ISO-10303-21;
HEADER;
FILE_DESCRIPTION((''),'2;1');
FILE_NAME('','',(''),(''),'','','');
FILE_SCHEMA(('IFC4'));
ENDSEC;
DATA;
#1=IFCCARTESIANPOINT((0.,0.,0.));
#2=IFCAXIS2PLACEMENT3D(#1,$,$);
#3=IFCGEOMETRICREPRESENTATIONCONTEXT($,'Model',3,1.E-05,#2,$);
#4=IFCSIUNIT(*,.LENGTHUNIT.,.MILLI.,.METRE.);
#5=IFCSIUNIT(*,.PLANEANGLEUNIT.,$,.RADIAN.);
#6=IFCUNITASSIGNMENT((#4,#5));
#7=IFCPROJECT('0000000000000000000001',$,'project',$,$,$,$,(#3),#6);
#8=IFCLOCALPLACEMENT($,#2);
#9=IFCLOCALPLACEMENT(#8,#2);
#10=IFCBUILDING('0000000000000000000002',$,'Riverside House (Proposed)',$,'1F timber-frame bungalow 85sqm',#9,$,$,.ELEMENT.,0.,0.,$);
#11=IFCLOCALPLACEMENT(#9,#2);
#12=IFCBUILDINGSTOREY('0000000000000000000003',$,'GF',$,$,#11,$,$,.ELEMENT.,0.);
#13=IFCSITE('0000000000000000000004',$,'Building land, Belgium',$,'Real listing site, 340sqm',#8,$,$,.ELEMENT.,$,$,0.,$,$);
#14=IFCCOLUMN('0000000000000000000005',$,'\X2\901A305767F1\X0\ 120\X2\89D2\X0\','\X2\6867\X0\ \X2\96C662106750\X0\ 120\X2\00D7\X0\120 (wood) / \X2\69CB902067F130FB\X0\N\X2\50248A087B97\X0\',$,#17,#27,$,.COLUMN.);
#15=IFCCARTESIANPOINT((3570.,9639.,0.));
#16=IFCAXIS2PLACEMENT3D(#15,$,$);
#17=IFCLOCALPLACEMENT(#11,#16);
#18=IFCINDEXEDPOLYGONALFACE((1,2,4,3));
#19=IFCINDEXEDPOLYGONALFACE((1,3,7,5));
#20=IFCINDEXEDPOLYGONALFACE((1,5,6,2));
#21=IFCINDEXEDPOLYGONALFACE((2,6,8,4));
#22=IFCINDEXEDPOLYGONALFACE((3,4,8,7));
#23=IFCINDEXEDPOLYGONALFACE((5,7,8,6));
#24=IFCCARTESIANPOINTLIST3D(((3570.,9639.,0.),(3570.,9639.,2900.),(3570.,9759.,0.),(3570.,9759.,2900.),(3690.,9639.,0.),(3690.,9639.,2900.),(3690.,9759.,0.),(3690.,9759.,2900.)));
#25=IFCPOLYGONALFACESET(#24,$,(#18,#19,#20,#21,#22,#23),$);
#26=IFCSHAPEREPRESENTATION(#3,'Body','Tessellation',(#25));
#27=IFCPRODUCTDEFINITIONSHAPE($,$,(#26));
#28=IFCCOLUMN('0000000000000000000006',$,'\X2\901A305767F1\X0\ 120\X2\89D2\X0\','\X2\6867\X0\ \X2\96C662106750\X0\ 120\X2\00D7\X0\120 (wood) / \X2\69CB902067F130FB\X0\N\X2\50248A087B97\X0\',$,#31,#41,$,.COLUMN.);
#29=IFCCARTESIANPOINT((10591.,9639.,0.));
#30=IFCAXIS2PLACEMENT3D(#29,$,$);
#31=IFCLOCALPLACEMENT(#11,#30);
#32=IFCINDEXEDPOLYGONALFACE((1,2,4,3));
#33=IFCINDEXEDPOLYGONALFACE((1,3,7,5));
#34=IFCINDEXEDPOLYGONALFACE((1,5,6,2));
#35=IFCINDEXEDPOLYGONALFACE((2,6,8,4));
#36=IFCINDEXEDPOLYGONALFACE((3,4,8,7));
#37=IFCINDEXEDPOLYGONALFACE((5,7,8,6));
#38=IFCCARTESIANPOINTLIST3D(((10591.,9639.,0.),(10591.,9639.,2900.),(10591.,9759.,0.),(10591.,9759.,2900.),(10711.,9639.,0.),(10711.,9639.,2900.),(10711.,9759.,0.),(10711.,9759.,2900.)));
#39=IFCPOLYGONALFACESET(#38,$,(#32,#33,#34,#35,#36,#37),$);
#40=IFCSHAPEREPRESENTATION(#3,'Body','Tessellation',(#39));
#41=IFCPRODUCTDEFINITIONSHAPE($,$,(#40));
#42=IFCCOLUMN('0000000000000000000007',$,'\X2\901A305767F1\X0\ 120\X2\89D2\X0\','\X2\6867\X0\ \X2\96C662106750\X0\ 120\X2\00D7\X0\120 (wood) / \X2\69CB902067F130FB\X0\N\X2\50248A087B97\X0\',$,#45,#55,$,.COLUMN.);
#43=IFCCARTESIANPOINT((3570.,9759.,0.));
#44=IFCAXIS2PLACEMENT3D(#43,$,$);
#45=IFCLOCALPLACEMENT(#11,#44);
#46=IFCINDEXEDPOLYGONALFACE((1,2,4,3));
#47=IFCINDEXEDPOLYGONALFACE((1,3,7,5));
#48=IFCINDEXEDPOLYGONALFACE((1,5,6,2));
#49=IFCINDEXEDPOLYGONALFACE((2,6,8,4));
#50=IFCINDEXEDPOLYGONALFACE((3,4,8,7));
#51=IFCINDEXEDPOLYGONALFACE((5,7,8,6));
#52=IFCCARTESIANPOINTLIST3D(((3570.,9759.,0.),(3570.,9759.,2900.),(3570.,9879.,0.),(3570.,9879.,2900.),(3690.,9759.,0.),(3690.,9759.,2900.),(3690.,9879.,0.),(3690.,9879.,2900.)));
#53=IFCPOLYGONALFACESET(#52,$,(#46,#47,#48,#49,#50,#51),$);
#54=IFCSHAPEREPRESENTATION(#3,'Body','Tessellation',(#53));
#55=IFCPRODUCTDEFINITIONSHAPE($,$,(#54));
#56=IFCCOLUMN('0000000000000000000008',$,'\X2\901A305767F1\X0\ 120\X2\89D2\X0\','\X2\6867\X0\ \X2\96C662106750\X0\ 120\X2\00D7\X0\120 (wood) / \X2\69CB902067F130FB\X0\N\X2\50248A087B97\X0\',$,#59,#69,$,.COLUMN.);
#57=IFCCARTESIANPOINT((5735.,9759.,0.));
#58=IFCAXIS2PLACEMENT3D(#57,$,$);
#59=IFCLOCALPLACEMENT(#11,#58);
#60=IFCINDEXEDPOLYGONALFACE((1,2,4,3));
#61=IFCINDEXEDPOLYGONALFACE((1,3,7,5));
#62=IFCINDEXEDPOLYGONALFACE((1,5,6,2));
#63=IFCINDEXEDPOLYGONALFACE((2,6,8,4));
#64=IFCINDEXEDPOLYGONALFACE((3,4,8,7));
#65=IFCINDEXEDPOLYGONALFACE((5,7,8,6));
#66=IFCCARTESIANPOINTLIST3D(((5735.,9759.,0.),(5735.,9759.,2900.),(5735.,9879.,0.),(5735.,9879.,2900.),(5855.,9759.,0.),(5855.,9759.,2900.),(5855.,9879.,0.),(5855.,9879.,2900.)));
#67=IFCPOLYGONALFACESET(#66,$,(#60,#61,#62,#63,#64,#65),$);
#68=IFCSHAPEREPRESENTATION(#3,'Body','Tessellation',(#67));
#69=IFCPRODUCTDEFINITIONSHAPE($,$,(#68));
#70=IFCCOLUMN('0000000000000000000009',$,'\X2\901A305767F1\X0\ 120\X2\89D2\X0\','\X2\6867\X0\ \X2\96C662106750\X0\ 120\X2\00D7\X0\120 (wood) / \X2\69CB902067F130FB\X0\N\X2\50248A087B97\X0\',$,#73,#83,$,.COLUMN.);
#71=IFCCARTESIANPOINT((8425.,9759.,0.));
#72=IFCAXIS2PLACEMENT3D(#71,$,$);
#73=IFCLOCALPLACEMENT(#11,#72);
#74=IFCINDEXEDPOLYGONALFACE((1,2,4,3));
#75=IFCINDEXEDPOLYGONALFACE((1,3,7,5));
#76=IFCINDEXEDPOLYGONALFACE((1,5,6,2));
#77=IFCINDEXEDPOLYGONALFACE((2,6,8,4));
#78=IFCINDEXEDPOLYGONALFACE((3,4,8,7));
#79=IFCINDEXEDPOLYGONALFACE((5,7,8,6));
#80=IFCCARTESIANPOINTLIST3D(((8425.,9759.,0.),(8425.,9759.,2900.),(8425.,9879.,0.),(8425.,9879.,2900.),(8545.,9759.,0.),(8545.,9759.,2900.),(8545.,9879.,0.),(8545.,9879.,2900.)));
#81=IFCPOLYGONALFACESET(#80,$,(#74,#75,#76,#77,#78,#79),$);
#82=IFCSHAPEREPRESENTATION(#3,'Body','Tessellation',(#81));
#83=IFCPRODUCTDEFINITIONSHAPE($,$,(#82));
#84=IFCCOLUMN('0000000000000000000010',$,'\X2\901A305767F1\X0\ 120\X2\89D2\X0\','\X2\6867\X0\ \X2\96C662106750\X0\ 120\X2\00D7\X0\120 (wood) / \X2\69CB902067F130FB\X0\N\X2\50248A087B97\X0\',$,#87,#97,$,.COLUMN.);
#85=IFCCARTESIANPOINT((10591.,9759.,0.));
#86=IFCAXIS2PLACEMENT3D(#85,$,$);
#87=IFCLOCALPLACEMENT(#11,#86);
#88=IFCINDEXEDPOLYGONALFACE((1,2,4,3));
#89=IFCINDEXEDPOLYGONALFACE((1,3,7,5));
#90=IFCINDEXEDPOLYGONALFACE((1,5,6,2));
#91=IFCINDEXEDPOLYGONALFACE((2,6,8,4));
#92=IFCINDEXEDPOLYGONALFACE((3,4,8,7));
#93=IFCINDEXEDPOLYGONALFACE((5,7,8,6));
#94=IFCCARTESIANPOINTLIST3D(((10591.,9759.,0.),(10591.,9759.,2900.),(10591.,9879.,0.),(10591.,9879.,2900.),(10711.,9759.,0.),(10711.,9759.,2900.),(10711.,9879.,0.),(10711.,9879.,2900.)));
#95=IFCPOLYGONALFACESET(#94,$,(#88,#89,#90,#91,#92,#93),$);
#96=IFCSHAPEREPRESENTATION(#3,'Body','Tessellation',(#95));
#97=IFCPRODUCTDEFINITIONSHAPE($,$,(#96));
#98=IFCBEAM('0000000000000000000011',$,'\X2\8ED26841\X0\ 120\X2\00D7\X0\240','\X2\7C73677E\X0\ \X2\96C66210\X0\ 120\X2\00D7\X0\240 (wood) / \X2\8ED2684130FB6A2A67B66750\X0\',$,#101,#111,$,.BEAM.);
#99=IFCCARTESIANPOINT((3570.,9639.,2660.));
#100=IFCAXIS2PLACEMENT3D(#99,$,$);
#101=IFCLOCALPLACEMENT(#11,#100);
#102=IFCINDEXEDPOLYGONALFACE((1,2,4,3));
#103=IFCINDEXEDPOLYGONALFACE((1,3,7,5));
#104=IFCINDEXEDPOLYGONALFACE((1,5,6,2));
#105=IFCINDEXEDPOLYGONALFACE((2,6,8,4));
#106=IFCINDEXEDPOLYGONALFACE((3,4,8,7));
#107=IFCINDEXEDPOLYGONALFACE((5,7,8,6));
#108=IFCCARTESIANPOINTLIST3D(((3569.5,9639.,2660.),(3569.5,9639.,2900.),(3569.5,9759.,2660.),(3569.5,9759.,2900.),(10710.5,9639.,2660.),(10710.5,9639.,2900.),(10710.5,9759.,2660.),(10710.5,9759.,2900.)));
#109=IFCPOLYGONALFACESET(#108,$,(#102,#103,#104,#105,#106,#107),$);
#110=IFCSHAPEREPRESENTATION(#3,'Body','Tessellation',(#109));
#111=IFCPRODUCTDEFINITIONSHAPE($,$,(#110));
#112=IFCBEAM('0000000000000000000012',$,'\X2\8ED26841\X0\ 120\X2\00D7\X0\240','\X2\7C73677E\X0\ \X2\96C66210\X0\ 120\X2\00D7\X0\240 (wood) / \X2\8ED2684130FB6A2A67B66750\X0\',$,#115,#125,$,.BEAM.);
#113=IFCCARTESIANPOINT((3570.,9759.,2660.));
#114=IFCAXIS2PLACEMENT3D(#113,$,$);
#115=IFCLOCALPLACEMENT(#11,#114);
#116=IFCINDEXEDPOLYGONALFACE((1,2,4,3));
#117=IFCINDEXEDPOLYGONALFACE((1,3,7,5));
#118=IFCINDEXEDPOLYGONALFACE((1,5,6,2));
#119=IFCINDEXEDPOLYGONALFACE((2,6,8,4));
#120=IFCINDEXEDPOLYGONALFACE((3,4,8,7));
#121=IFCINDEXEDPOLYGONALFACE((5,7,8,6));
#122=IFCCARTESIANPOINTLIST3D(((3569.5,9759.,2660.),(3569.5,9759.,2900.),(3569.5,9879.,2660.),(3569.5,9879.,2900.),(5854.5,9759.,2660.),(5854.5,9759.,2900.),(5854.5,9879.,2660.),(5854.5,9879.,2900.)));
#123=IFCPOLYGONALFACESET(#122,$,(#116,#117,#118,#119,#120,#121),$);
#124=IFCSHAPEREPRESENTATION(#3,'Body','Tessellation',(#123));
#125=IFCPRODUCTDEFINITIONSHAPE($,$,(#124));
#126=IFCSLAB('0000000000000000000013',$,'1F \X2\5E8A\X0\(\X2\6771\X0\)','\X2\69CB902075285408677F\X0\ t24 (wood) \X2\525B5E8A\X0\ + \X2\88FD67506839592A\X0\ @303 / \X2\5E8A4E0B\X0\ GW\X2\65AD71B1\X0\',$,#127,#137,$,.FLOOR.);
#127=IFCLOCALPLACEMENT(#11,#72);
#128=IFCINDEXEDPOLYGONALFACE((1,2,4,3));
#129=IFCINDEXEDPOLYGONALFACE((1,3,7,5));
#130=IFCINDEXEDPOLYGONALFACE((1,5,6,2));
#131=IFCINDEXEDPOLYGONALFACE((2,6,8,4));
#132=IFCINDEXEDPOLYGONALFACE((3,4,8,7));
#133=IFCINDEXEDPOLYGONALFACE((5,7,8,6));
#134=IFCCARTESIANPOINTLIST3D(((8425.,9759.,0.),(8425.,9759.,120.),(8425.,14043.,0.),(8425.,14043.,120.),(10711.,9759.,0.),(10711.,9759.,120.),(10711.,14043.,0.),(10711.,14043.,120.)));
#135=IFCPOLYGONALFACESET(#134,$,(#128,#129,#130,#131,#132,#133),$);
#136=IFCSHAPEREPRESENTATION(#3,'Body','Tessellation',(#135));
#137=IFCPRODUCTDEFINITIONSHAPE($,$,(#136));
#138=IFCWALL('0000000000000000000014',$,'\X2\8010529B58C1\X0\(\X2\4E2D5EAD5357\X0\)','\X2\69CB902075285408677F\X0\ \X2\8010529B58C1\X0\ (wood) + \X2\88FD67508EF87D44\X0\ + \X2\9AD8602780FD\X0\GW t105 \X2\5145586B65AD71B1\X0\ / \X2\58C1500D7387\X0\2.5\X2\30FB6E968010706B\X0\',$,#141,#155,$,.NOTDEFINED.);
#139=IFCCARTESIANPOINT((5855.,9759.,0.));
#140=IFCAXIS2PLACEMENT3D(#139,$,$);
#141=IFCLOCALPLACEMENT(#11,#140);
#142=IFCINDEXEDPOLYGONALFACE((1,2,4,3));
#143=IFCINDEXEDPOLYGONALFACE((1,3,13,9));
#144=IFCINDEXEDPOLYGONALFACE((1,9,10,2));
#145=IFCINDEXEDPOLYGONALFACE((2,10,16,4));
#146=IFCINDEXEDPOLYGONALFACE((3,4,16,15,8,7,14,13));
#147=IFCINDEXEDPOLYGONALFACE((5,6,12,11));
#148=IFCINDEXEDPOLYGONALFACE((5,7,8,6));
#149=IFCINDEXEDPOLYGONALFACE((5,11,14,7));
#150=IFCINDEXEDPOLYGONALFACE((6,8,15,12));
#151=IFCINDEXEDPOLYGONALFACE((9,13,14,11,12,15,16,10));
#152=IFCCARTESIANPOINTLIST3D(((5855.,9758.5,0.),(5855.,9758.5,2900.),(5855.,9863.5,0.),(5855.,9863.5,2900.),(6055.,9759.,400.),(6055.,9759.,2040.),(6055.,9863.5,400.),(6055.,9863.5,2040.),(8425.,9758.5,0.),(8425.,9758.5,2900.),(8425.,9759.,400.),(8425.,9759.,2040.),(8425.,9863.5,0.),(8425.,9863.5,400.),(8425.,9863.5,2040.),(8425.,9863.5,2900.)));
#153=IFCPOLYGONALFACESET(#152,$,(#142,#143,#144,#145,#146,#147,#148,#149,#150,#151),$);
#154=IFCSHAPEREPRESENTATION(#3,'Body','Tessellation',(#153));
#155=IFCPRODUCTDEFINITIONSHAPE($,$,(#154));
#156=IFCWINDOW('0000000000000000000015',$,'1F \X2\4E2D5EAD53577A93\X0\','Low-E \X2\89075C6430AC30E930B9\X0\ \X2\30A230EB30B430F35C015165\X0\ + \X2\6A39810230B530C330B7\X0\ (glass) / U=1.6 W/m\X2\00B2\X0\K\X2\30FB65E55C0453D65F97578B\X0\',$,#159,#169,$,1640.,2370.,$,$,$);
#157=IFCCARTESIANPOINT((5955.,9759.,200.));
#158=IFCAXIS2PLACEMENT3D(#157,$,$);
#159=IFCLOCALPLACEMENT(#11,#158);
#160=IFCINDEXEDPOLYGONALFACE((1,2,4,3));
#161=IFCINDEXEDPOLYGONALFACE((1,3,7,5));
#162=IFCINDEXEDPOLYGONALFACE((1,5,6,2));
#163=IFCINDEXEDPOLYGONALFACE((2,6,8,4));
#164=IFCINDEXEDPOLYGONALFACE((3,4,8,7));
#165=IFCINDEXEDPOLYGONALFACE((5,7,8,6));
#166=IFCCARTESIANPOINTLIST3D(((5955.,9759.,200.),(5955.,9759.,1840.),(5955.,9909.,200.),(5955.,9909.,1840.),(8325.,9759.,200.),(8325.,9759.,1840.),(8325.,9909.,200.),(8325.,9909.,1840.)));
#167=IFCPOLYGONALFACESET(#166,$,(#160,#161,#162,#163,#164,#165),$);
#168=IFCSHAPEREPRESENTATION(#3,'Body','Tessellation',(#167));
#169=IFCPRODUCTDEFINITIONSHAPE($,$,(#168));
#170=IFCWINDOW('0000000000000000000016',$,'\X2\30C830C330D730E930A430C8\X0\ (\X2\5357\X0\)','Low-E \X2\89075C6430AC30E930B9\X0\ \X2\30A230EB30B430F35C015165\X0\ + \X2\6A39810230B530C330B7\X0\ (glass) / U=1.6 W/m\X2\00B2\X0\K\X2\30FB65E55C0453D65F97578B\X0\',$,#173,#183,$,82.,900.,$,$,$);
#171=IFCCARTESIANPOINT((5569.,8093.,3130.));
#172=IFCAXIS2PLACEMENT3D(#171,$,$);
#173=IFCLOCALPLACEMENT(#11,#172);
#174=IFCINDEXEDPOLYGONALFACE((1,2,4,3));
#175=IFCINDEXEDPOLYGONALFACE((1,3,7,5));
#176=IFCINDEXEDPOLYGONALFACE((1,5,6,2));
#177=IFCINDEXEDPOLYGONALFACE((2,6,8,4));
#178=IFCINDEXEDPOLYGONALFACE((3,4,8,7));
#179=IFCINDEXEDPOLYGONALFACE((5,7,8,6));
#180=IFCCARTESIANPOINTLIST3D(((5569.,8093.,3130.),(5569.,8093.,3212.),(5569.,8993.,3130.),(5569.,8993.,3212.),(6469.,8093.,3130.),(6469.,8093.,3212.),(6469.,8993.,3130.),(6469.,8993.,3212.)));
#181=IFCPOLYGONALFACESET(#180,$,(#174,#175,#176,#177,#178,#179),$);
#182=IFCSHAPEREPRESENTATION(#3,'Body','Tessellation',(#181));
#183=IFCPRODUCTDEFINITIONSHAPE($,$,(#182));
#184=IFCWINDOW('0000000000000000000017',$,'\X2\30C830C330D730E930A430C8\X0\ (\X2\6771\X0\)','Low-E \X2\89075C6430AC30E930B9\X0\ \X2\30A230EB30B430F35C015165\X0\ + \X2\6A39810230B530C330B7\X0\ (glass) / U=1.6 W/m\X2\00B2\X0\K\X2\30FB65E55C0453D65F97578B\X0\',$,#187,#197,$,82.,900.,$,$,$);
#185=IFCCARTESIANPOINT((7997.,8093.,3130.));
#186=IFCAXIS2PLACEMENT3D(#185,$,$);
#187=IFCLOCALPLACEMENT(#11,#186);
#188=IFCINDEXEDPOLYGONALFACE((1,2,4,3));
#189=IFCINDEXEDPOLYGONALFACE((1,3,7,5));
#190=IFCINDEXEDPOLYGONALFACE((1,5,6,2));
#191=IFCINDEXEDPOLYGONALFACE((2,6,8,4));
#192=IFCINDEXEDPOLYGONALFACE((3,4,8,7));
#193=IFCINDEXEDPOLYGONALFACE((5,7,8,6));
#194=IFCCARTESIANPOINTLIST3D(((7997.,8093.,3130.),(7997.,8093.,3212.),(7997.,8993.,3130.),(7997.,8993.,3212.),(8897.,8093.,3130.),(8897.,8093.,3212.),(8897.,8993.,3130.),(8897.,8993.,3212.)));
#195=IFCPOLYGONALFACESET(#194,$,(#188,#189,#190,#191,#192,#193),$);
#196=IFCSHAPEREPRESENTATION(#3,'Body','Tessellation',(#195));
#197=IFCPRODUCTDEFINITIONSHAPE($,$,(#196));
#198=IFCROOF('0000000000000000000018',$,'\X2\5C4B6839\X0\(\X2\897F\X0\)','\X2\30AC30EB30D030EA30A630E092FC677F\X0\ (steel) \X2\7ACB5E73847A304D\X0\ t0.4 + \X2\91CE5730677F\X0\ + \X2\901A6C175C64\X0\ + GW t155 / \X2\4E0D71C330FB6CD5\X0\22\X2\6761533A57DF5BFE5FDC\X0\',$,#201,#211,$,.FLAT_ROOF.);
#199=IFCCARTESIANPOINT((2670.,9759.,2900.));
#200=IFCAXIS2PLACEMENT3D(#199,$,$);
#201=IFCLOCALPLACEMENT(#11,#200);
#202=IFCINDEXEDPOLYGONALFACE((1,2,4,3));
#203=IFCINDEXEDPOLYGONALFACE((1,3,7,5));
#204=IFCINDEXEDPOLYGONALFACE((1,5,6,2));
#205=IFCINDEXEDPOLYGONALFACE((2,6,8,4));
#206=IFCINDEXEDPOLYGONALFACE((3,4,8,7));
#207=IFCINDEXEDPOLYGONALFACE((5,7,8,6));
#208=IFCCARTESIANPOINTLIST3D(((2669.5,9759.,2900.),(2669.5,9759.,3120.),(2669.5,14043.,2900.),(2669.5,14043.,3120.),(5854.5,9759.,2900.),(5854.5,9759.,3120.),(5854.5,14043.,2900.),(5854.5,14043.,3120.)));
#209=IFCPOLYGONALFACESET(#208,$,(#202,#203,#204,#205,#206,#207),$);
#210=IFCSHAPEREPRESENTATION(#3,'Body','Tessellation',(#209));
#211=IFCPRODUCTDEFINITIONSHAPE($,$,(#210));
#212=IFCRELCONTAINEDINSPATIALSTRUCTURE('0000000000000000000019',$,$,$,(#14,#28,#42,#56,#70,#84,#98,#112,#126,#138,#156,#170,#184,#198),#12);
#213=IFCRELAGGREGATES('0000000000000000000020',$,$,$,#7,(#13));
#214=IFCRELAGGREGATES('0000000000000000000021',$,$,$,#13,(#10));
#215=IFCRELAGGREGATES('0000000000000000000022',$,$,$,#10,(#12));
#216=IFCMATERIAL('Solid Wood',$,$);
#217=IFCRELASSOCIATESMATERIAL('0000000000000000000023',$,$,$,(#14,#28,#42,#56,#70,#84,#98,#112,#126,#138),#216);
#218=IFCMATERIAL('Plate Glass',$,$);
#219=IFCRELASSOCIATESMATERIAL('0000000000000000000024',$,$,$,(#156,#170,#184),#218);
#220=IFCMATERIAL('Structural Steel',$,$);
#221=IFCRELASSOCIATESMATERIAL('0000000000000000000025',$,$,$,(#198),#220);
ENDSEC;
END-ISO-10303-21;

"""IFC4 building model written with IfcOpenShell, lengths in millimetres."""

from ifc_helpers import new_model, si_unit, frame, frame_2d, origin, place, context, project, spatial, rectangle, extrude, material, element, fill, save


model = new_model("IFC4")

# Units and contexts
model_context = context("Model", 3, precision=1e-05, world=origin())
ifc_project = project(units=[si_unit("LENGTHUNIT", "METRE", prefix="MILLI"), si_unit("PLANEANGLEUNIT", "RADIAN")], contexts=[model_context])

# Site, building, storey
site_placement = place(None, origin())
site = spatial("IfcSite", under=ifc_project, at=site_placement, Name="Building land, Belgium", ObjectType="Real listing site, 340sqm", CompositionType="ELEMENT", RefElevation=0.0)
building_placement = place(site_placement, origin())
building = spatial("IfcBuilding", under=site, at=building_placement, Name="Riverside House (Proposed)", ObjectType="1F timber-frame bungalow 85sqm", CompositionType="ELEMENT", ElevationOfRefHeight=0.0, ElevationOfTerrain=0.0)
storey_placement = place(building_placement, origin())
storey = spatial("IfcBuildingStorey", under=building, at=storey_placement, Name="GF", CompositionType="ELEMENT", Elevation=0.0)

# Columns
ifc_material_1 = material(Name="Solid Wood")
column_1_placement = place(storey_placement, frame((3570.0, 9639.0, 0.0)))
element("IfcColumn", 1, at=column_1_placement, inside=storey, material=ifc_material_1, Name="通し柱 120角", Description="桧 集成材 120×120 (wood) / 構造柱・N値計算", PredefinedType="COLUMN", context=model_context, shape_type="SweptSolid", body=[
    extrude(rectangle(XDim=120.0, YDim=120.0, at=frame_2d((60.0, 60.0))), frame((3570.0, 9639.0, 0.0)), (0.0, 0.0, 1.0), 2900.0),
])
column_2_placement = place(storey_placement, frame((10591.0, 9639.0, 0.0)))
element("IfcColumn", 2, at=column_2_placement, inside=storey, material=ifc_material_1, Name="通し柱 120角", Description="桧 集成材 120×120 (wood) / 構造柱・N値計算", PredefinedType="COLUMN", context=model_context, shape_type="SweptSolid", body=[
    extrude(rectangle(XDim=120.0, YDim=120.0, at=frame_2d((60.0, 60.0))), frame((10591.0, 9639.0, 0.0)), (0.0, 0.0, 1.0), 2900.0),
])
column_3_placement = place(storey_placement, frame((3570.0, 9759.0, 0.0)))
element("IfcColumn", 3, at=column_3_placement, inside=storey, material=ifc_material_1, Name="通し柱 120角", Description="桧 集成材 120×120 (wood) / 構造柱・N値計算", PredefinedType="COLUMN", context=model_context, shape_type="SweptSolid", body=[
    extrude(rectangle(XDim=120.0, YDim=120.0, at=frame_2d((60.0, 60.0))), frame((3570.0, 9759.0, 0.0)), (0.0, 0.0, 1.0), 2900.0),
])
column_4_placement = place(storey_placement, frame((5735.0, 9759.0, 0.0)))
element("IfcColumn", 4, at=column_4_placement, inside=storey, material=ifc_material_1, Name="通し柱 120角", Description="桧 集成材 120×120 (wood) / 構造柱・N値計算", PredefinedType="COLUMN", context=model_context, shape_type="SweptSolid", body=[
    extrude(rectangle(XDim=120.0, YDim=120.0, at=frame_2d((60.0, 60.0))), frame((5735.0, 9759.0, 0.0)), (0.0, 0.0, 1.0), 2900.0),
])
column_5_placement = place(storey_placement, frame((8425.0, 9759.0, 0.0)))
element("IfcColumn", 5, at=column_5_placement, inside=storey, material=ifc_material_1, Name="通し柱 120角", Description="桧 集成材 120×120 (wood) / 構造柱・N値計算", PredefinedType="COLUMN", context=model_context, shape_type="SweptSolid", body=[
    extrude(rectangle(XDim=120.0, YDim=120.0, at=frame_2d((60.0, 60.0))), frame((8425.0, 9759.0, 0.0)), (0.0, 0.0, 1.0), 2900.0),
])
column_6_placement = place(storey_placement, frame((10591.0, 9759.0, 0.0)))
element("IfcColumn", 6, at=column_6_placement, inside=storey, material=ifc_material_1, Name="通し柱 120角", Description="桧 集成材 120×120 (wood) / 構造柱・N値計算", PredefinedType="COLUMN", context=model_context, shape_type="SweptSolid", body=[
    extrude(rectangle(XDim=120.0, YDim=120.0, at=frame_2d((60.0, 60.0))), frame((10591.0, 9759.0, 0.0)), (0.0, 0.0, 1.0), 2900.0),
])

# Beams
beam_1_placement = place(storey_placement, frame((3570.0, 9639.0, 2660.0)))
element("IfcBeam", 7, at=beam_1_placement, inside=storey, material=ifc_material_1, Name="軒桁 120×240", Description="米松 集成 120×240 (wood) / 軒桁・横架材", PredefinedType="BEAM", context=model_context, shape_type="SweptSolid", body=[
    extrude(rectangle(XDim=7141.0, YDim=120.0, at=frame_2d((3570.0, 60.0))), frame((3570.0, 9639.0, 2660.0)), (0.0, 0.0, 1.0), 240.0),
])
beam_2_placement = place(storey_placement, frame((3570.0, 9759.0, 2660.0)))
element("IfcBeam", 8, at=beam_2_placement, inside=storey, material=ifc_material_1, Name="軒桁 120×240", Description="米松 集成 120×240 (wood) / 軒桁・横架材", PredefinedType="BEAM", context=model_context, shape_type="SweptSolid", body=[
    extrude(rectangle(XDim=2285.0, YDim=120.0, at=frame_2d((1142.0, 60.0))), frame((3570.0, 9759.0, 2660.0)), (0.0, 0.0, 1.0), 240.0),
])

# Slab
slab_1_placement = place(storey_placement, frame((8425.0, 9759.0, 0.0)))
element("IfcSlab", 9, at=slab_1_placement, inside=storey, material=ifc_material_1, Name="1F 床(東)", Description="構造用合板 t24 (wood) 剛床 + 製材根太 @303 / 床下 GW断熱", PredefinedType="FLOOR", context=model_context, shape_type="SweptSolid", body=[
    extrude(rectangle(XDim=2286.0, YDim=4284.0, at=frame_2d((1143.0, 2142.0))), frame((8425.0, 9759.0, 0.0)), (0.0, 0.0, 1.0), 120.0),
])

# Wall, opening, window
wall_1_placement = place(storey_placement, frame((5855.0, 9759.0, 0.0)))
wall_1 = element("IfcWall", 10, at=wall_1_placement, inside=storey, material=ifc_material_1, Name="耐力壁(中庭南)", Description="構造用合板 耐力壁 (wood) + 製材軸組 + 高性能GW t105 充填断熱 / 壁倍率2.5・準耐火", PredefinedType="NOTDEFINED", context=model_context, shape_type="SweptSolid", body=[
    extrude(rectangle(XDim=2570.0, YDim=105.0, at=frame_2d((1285.0, 52.0))), frame((5855.0, 9759.0, 0.0)), (0.0, 0.0, 1.0), 2900.0),
])
opening_placement = place(storey_placement, frame((5955.0, 9759.0, 200.0)))
opening = element("IfcOpeningElement", 11, at=opening_placement, cuts=wall_1, PredefinedType="NOTDEFINED", context=model_context, shape_type="SweptSolid", body=[
    extrude(rectangle(XDim=2370.0, YDim=150.0, at=frame_2d((1185.0, 75.0))), frame((5955.0, 9759.0, 200.0)), (0.0, 0.0, 1.0), 1640.0),
])
ifc_material_2 = material(Name="Plate Glass")
window_1_placement = place(storey_placement, frame((5955.0, 9759.0, 200.0)))
window_1 = element("IfcWindow", 12, at=window_1_placement, inside=storey, material=ifc_material_2, Name="1F 中庭南窓", Description="Low-E 複層ガラス アルゴン封入 + 樹脂サッシ (glass) / U=1.6 W/m²K・日射取得型", OverallHeight=1640.0, OverallWidth=2370.0, context=model_context, shape_type="SweptSolid", body=[
    extrude(rectangle(XDim=2370.0, YDim=150.0, at=frame_2d((1185.0, 75.0))), frame((5955.0, 9759.0, 200.0)), (0.0, 0.0, 1.0), 1640.0),
])
fill(opening, window_1)

# Windows
window_2_placement = place(storey_placement, frame((5569.0, 8093.0, 3130.0)))
element("IfcWindow", 13, at=window_2_placement, inside=storey, material=ifc_material_2, Name="トップライト (南)", Description="Low-E 複層ガラス アルゴン封入 + 樹脂サッシ (glass) / U=1.6 W/m²K・日射取得型", OverallHeight=82.0, OverallWidth=900.0, context=model_context, shape_type="SweptSolid", body=[
    extrude(rectangle(XDim=900.0, YDim=900.0, at=frame_2d((450.0, 450.0))), frame((5569.0, 8093.0, 3130.0)), (0.0, 0.0, 1.0), 82.0),
])
window_3_placement = place(storey_placement, frame((7997.0, 8093.0, 3130.0)))
element("IfcWindow", 14, at=window_3_placement, inside=storey, material=ifc_material_2, Name="トップライト (東)", Description="Low-E 複層ガラス アルゴン封入 + 樹脂サッシ (glass) / U=1.6 W/m²K・日射取得型", OverallHeight=82.0, OverallWidth=900.0, context=model_context, shape_type="SweptSolid", body=[
    extrude(rectangle(XDim=900.0, YDim=900.0, at=frame_2d((450.0, 450.0))), frame((7997.0, 8093.0, 3130.0)), (0.0, 0.0, 1.0), 82.0),
])

# Roof
ifc_material_3 = material(Name="Structural Steel")
roof_1_placement = place(storey_placement, frame((2670.0, 9759.0, 2900.0)))
element("IfcRoof", 15, at=roof_1_placement, inside=storey, material=ifc_material_3, Name="屋根(西)", Description="ガルバリウム鋼板 (steel) 立平葺き t0.4 + 野地板 + 通気層 + GW t155 / 不燃・法22条区域対応", PredefinedType="FLAT_ROOF", context=model_context, shape_type="SweptSolid", body=[
    extrude(rectangle(XDim=3185.0, YDim=4284.0, at=frame_2d((1592.0, 2142.0))), frame((2670.0, 9759.0, 2900.0)), (0.0, 0.0, 1.0), 220.0),
])

save(model, "model.ifc")
